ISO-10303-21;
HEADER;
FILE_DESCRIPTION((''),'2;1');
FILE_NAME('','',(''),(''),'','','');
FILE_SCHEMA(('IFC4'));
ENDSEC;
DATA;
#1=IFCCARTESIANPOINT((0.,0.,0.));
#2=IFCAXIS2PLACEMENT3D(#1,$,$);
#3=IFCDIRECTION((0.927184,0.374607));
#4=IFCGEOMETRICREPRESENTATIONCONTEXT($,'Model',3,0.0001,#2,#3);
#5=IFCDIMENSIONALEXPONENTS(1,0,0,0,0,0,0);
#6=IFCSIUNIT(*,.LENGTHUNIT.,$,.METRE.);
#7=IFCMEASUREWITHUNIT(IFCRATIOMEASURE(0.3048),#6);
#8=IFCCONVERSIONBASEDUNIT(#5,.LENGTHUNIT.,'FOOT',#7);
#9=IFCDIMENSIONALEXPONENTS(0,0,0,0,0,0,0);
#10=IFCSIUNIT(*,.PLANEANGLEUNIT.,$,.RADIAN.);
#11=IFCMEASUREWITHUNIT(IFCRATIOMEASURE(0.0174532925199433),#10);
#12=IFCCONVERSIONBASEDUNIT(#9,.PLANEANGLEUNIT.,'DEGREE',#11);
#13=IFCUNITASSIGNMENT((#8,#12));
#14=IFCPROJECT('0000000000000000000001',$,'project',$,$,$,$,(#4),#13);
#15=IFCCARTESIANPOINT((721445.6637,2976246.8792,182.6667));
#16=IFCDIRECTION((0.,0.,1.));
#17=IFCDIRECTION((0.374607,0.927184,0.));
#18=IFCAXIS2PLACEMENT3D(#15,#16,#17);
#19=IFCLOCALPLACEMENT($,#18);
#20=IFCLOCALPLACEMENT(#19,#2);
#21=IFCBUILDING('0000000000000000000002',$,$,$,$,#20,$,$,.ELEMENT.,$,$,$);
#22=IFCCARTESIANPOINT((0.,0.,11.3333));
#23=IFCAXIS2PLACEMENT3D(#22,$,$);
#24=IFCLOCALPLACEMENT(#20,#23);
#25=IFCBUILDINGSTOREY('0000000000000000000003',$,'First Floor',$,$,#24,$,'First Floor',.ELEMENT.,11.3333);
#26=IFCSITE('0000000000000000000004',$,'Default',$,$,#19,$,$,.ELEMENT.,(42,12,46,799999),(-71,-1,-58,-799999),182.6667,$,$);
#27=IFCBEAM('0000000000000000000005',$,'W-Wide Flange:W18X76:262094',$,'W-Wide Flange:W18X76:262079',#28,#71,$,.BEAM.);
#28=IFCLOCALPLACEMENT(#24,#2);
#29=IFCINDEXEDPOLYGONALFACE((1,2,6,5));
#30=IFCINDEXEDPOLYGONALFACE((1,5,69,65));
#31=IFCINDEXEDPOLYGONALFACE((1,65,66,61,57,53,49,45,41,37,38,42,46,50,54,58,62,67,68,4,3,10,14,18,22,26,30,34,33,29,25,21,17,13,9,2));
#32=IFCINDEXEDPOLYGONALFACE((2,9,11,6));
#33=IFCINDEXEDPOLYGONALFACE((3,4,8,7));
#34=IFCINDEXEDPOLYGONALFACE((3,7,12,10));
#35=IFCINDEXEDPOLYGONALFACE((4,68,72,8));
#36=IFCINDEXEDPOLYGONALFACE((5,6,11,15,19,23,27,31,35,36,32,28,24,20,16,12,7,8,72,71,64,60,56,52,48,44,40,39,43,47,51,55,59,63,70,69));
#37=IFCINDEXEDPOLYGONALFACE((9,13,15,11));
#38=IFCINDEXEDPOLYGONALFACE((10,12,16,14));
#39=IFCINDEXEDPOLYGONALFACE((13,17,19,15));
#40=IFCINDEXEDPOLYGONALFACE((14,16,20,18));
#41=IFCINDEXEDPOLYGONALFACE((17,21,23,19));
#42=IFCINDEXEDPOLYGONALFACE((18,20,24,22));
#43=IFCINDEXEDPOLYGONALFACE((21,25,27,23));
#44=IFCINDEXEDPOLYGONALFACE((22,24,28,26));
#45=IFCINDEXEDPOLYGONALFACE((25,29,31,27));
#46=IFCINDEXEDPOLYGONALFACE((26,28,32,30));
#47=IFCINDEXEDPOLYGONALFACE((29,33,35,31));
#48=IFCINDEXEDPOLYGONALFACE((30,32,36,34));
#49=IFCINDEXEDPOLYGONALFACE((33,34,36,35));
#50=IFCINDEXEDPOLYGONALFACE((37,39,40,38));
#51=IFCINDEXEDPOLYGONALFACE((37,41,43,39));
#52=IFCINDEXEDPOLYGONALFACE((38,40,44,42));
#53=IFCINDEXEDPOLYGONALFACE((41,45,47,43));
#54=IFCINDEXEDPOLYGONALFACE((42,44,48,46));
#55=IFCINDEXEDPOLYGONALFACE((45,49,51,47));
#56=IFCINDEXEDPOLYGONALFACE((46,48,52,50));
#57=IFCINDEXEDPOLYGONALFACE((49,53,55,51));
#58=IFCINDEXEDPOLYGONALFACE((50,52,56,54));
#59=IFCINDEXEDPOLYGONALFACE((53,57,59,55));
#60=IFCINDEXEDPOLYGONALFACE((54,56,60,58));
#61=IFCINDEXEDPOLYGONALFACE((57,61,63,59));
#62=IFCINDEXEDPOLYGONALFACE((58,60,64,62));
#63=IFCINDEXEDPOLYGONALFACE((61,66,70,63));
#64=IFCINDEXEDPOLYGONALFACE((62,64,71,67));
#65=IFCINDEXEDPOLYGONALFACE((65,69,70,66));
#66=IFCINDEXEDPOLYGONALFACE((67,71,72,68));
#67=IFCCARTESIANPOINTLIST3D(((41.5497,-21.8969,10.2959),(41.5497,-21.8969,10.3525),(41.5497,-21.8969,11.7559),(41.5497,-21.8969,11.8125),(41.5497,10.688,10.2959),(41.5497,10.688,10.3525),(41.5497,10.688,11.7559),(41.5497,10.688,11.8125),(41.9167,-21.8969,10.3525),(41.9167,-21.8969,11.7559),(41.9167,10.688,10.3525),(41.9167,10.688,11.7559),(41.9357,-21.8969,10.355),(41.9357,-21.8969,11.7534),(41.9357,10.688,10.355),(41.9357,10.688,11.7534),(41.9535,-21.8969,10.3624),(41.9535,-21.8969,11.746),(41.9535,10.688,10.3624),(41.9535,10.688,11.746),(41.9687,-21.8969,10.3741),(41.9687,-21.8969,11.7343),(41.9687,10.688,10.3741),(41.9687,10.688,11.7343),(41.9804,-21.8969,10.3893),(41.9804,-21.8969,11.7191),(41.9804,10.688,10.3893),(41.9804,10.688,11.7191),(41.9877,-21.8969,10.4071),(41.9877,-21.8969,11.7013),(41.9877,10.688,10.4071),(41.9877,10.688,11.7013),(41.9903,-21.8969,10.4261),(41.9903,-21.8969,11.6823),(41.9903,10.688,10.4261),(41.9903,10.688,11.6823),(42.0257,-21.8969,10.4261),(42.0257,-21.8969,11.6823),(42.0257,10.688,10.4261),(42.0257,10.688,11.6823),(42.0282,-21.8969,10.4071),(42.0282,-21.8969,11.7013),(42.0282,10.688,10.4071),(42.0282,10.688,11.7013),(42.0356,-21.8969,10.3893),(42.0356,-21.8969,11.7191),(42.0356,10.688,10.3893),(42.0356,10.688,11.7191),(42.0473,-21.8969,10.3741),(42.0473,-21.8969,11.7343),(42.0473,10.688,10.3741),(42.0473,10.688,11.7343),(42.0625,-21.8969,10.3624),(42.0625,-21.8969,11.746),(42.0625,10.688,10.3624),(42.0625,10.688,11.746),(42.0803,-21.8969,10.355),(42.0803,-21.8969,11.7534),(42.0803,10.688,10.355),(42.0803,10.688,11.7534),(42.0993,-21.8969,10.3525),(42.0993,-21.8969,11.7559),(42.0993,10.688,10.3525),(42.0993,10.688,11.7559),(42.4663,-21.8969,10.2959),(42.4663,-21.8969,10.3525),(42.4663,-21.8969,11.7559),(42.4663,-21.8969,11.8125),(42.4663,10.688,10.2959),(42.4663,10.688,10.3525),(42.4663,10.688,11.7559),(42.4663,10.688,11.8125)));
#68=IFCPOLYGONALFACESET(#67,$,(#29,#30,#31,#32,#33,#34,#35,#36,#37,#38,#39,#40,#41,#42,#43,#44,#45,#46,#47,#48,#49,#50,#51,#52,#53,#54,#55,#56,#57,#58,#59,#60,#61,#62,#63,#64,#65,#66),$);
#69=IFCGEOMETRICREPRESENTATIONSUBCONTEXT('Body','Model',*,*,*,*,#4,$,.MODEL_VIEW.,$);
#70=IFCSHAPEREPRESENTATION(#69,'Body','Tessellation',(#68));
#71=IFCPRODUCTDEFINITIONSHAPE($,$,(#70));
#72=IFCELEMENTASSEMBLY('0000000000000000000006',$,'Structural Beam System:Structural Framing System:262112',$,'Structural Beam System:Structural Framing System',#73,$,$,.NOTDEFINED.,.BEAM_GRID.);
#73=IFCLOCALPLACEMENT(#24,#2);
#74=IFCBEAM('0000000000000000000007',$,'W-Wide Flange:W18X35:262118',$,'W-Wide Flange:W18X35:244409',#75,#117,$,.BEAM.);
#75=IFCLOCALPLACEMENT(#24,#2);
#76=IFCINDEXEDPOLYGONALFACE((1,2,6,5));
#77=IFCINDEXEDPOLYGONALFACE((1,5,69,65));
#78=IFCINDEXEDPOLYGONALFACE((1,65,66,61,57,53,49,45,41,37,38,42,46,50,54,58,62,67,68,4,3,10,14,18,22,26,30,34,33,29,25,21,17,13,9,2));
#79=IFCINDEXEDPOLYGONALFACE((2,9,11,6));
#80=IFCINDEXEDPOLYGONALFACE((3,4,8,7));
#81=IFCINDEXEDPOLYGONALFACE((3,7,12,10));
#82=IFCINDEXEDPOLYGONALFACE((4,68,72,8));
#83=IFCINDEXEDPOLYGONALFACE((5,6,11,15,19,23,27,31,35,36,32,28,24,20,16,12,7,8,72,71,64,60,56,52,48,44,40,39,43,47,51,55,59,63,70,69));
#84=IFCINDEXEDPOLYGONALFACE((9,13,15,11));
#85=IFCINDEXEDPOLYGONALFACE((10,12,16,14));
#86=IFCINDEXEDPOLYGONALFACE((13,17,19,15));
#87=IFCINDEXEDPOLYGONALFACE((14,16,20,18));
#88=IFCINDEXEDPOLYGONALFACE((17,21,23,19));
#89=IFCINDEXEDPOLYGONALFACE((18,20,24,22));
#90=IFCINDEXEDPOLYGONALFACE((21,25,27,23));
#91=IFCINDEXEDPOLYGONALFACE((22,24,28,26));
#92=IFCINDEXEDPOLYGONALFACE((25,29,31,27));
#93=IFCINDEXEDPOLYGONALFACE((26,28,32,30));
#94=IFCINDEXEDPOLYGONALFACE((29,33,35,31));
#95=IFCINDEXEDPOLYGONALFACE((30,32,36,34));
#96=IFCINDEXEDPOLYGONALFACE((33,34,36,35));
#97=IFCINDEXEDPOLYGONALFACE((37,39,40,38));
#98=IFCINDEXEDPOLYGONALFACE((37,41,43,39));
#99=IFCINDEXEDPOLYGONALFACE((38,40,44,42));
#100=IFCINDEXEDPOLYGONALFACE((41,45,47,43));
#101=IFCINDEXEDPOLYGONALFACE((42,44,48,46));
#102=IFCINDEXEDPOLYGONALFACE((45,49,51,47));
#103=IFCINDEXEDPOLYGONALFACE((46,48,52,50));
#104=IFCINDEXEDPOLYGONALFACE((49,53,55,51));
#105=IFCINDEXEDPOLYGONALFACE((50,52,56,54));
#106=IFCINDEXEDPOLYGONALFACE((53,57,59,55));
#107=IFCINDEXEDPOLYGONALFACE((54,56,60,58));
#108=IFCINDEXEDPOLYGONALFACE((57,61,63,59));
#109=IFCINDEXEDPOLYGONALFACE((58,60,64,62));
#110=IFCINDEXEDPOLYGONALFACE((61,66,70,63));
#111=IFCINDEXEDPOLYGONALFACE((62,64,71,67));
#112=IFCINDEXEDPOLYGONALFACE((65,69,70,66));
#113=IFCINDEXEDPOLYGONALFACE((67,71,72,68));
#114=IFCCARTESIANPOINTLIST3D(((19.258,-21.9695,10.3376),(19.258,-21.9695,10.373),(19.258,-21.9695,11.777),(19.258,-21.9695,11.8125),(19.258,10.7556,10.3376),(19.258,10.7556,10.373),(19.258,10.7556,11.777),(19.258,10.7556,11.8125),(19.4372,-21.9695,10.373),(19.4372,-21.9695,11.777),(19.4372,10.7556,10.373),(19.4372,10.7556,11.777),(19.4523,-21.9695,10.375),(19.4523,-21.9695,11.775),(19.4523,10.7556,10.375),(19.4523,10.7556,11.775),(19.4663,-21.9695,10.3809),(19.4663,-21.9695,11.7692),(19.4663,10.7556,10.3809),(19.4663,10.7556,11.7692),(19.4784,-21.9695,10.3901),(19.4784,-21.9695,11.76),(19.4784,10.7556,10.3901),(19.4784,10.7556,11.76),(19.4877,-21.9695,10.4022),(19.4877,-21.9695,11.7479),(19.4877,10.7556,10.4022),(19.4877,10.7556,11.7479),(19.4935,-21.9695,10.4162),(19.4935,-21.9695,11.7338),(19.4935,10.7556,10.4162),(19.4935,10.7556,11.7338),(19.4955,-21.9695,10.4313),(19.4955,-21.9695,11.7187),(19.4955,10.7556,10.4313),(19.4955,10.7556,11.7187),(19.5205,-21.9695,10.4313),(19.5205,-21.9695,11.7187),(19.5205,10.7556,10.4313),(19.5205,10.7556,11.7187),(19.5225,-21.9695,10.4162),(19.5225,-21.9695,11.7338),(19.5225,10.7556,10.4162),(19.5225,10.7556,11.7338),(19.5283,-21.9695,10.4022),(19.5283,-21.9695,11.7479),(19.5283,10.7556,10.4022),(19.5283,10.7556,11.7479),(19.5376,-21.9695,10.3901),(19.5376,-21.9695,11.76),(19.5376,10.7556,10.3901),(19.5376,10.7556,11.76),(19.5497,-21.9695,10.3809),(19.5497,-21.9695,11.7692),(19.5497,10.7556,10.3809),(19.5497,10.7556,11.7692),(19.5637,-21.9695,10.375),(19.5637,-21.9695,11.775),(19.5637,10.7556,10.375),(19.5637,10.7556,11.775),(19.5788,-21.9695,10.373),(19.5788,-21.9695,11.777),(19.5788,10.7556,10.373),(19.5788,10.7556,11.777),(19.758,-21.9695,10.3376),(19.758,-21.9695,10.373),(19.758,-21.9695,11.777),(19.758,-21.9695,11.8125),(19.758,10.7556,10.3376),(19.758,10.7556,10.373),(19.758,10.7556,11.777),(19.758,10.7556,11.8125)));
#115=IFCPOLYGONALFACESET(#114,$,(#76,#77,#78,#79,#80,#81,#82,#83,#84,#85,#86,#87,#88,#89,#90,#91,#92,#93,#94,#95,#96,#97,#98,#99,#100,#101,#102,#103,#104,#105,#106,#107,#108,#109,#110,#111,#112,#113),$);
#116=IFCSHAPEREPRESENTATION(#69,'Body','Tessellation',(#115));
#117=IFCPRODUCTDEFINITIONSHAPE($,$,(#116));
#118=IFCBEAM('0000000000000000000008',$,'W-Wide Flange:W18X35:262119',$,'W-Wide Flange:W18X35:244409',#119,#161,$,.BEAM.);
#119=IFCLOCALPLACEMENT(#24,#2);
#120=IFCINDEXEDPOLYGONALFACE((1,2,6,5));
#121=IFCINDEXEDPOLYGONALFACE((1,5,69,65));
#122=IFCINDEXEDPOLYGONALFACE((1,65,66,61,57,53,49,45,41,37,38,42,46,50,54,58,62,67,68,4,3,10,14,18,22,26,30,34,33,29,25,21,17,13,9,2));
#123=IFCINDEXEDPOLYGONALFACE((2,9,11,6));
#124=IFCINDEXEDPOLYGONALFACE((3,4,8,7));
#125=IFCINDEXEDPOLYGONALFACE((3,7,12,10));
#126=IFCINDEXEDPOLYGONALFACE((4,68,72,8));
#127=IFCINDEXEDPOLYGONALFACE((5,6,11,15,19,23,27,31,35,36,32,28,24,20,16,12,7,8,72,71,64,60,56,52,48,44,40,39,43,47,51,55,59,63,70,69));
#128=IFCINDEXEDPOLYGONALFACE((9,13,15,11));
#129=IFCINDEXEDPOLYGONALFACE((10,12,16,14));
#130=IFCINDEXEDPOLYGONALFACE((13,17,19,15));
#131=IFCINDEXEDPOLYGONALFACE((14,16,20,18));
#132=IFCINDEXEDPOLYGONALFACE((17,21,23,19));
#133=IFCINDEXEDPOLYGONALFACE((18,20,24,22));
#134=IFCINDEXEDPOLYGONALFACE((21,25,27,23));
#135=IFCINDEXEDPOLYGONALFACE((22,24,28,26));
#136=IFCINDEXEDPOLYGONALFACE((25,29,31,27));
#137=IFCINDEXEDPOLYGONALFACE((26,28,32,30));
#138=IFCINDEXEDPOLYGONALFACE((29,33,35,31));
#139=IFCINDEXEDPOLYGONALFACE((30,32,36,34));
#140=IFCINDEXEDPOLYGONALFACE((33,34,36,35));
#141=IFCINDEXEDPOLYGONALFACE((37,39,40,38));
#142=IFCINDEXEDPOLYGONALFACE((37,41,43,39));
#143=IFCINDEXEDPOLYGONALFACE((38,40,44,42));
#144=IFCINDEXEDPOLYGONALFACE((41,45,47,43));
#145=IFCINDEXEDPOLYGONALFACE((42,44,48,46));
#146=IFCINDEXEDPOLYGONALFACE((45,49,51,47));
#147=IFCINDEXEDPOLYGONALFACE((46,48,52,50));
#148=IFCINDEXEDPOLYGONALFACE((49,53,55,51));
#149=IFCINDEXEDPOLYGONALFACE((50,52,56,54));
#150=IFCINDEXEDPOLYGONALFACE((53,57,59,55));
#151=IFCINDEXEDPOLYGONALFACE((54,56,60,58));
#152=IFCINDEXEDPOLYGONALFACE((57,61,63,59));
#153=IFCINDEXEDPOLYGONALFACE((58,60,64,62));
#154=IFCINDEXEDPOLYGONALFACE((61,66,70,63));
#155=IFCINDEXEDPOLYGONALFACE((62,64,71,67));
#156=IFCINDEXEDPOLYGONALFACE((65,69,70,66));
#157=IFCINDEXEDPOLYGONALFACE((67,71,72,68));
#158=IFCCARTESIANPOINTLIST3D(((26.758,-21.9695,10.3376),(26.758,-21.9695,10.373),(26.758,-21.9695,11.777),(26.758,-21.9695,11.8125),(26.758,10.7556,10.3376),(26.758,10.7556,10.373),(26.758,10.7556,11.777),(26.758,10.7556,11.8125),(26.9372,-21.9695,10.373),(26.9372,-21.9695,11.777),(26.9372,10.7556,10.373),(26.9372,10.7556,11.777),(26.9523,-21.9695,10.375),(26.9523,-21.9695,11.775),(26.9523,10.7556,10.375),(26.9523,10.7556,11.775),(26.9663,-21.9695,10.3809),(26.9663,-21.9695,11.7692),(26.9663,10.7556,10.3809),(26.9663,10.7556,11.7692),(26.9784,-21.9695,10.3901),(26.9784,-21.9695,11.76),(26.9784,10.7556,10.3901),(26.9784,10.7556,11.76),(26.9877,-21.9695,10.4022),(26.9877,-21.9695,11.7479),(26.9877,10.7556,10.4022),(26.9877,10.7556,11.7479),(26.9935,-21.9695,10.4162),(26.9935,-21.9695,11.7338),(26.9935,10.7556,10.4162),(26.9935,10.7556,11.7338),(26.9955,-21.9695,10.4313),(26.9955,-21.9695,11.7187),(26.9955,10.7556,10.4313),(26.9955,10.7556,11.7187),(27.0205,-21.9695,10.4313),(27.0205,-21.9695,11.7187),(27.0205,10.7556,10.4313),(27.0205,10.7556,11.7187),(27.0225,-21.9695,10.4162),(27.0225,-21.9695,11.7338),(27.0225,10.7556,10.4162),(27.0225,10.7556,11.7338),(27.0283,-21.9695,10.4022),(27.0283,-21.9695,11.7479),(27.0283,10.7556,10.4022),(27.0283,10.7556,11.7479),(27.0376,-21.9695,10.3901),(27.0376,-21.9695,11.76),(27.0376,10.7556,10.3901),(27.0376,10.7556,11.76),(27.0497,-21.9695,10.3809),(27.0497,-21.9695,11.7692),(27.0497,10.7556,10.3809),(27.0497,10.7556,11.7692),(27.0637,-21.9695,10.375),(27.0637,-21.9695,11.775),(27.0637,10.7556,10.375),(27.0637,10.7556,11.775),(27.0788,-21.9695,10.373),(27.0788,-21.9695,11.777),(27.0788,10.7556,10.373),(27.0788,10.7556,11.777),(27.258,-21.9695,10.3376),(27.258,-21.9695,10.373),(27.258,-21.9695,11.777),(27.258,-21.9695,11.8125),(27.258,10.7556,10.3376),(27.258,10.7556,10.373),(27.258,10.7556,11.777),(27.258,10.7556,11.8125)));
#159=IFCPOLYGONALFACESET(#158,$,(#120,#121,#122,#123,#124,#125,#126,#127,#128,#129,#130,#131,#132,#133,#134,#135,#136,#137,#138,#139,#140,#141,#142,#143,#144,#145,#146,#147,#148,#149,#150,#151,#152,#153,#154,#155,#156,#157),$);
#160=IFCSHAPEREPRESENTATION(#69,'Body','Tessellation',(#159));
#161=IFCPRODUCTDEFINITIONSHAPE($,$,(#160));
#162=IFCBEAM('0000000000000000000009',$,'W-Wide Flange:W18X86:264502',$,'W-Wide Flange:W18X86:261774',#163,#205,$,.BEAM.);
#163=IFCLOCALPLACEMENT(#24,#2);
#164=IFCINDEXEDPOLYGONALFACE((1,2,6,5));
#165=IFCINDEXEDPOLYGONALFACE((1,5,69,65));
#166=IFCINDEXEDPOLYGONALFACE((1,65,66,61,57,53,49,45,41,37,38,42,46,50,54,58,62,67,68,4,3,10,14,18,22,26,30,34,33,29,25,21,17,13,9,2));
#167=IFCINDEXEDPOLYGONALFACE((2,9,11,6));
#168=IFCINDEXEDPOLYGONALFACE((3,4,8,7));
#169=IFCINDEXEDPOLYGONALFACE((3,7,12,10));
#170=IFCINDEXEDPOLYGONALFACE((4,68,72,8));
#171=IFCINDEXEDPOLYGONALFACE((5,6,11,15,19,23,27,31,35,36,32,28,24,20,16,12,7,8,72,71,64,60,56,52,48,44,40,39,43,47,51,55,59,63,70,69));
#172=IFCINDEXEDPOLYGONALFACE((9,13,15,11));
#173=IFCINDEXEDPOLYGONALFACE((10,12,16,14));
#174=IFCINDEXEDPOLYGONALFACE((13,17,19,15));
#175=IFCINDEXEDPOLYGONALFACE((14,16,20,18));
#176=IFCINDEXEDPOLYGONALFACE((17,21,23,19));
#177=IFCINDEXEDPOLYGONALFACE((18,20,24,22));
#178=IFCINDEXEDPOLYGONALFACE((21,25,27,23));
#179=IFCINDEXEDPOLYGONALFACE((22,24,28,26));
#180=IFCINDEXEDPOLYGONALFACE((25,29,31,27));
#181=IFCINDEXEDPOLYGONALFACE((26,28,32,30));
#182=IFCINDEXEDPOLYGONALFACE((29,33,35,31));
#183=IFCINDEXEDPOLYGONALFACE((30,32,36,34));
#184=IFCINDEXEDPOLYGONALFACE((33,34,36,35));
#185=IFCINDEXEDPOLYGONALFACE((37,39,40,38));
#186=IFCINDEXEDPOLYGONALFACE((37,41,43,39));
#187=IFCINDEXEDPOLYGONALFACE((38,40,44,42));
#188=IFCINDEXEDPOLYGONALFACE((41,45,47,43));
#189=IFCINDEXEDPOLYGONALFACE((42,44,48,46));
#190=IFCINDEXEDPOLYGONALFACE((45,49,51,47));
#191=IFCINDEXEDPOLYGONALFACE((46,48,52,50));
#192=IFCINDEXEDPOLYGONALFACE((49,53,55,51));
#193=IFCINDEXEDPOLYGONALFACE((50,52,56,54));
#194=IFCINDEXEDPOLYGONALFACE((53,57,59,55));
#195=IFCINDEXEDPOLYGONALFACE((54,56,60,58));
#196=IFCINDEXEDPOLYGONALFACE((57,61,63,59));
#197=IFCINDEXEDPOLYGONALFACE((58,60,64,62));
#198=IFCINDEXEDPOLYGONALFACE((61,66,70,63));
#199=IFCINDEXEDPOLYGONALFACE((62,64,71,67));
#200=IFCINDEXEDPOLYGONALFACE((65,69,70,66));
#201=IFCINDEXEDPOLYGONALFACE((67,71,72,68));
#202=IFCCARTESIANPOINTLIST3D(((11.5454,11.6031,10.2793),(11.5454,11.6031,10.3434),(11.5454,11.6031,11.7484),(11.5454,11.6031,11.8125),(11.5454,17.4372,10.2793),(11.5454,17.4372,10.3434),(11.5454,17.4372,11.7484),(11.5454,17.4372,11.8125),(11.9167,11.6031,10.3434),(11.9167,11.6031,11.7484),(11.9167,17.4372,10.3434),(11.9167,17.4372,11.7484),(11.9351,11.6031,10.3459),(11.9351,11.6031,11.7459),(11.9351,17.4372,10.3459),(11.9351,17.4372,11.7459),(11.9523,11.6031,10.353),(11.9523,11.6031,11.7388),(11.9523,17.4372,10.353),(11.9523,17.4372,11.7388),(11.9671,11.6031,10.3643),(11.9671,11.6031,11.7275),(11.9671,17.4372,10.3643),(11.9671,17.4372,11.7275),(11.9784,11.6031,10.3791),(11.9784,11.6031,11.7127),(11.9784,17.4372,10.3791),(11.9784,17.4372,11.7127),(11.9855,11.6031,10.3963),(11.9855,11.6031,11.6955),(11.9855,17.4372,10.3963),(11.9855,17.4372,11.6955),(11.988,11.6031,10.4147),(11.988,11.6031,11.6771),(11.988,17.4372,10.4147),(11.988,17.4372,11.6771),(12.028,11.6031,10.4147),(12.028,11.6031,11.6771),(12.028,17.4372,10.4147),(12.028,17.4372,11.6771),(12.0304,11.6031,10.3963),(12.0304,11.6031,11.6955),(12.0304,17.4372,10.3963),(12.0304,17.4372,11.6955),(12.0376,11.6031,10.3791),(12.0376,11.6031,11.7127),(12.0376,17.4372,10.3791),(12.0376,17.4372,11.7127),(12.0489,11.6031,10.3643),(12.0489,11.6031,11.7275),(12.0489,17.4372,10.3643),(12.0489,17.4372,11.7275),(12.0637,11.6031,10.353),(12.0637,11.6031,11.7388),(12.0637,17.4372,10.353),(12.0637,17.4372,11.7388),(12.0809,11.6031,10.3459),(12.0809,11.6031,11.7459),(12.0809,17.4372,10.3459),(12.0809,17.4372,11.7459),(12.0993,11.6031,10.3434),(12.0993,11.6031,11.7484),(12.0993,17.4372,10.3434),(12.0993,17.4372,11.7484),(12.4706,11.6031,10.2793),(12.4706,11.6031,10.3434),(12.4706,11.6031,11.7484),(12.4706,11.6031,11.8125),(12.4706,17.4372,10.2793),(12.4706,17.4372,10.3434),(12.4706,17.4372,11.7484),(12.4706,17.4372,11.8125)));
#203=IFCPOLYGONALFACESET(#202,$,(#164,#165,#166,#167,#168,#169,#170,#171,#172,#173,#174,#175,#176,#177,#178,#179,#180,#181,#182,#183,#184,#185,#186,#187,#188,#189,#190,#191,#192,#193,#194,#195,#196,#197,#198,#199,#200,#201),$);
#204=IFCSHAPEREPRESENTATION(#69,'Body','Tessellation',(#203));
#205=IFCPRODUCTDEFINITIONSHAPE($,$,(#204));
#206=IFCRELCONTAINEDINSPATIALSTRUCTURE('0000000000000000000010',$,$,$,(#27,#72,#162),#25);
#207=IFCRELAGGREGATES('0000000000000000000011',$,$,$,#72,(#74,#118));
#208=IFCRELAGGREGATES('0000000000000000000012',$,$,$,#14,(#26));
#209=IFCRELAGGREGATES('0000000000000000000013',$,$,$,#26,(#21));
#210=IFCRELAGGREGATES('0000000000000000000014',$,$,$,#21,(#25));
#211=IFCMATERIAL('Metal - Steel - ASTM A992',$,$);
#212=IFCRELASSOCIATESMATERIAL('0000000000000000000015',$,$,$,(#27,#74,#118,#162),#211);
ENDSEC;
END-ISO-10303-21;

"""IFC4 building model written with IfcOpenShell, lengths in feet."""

from ifc_helpers import new_model, entity, si_unit, converted_unit, direction, frame, frame_2d, origin, place, context, subcontext, project, spatial, i_section, extrude, material, element, aggregate, save


model = new_model("IFC4")

# Units and contexts
model_context = context("Model", 3, precision=0.0001, world=origin(), true_north=direction((0.927184, 0.374607)))
body_context = subcontext(model_context, "Body", "Model", "MODEL_VIEW")
ifc_project = project(units=[converted_unit("LENGTHUNIT", "FOOT", entity("IfcRatioMeasure", 0.3048), si_unit("LENGTHUNIT", "METRE"), dimensions=[1, 0, 0, 0, 0, 0, 0]), converted_unit("PLANEANGLEUNIT", "DEGREE", entity("IfcRatioMeasure", 0.0174532925199433), si_unit("PLANEANGLEUNIT", "RADIAN"), dimensions=[0, 0, 0, 0, 0, 0, 0])], contexts=[model_context])

# Site, building, storey
site_placement = place(None, frame((721445.6637, 2976246.8792, 182.6667), z_axis=(0.0, 0.0, 1.0), x_axis=(0.374607, 0.927184, 0.0)))
site = spatial("IfcSite", under=ifc_project, at=site_placement, Name="Default", CompositionType="ELEMENT", RefLatitude=(42, 12, 46, 799999), RefLongitude=(-71, -1, -58, -799999), RefElevation=182.6667)
building_placement = place(site_placement, origin())
building = spatial("IfcBuilding", under=site, at=building_placement, CompositionType="ELEMENT")
storey_placement = place(building_placement, frame((0.0, 0.0, 11.3333)))
storey = spatial("IfcBuildingStorey", under=building, at=storey_placement, Name="First Floor", LongName="First Floor", CompositionType="ELEMENT", Elevation=11.3333)

# Shared definitions
ifc_material_1 = material(Name="Metal - Steel - ASTM A992")

# Beam
beam_1_placement = place(storey_placement, frame((42.008, -22.3544, 11.8125), z_axis=(0.0, 0.0, 1.0), x_axis=(0.0, 1.0, 0.0)))
element("IfcBeam", 1, at=beam_1_placement, inside=storey, material=ifc_material_1, Name="W-Wide Flange:W18X76:262094", ObjectType="W-Wide Flange:W18X76:262079", PredefinedType="BEAM", context=body_context, shape_type="SweptSolid", body=[
    extrude(i_section(OverallWidth=0.9167, OverallDepth=1.5166, WebThickness=0.0355, FlangeThickness=0.0566, FilletRadius=0.0736, at=frame_2d((0.0, 0.0), x_axis=(0.0, 1.0))), frame((0.4575, 0.0, -0.7583), z_axis=(1.0, 0.0, 0.0), x_axis=(0.0, 0.0, -1.0)), (0.0, 0.0, 1.0), 32.585),
])

# Element assembly, beams
assembly_1_placement = place(storey_placement, origin())
assembly_1 = element("IfcElementAssembly", 2, at=assembly_1_placement, inside=storey, Name="Structural Beam System:Structural Framing System:262112", ObjectType="Structural Beam System:Structural Framing System", AssemblyPlace="NOTDEFINED", PredefinedType="BEAM_GRID")
beam_2_placement = place(assembly_1_placement, frame((19.508, -22.3544, 11.8125), z_axis=(0.0, 0.0, 1.0), x_axis=(0.0, 1.0, 0.0)))
beam_2 = element("IfcBeam", 3, at=beam_2_placement, material=ifc_material_1, Name="W-Wide Flange:W18X35:262118", ObjectType="W-Wide Flange:W18X35:244409", PredefinedType="BEAM", context=body_context, shape_type="SweptSolid", body=[
    extrude(i_section(OverallWidth=0.5, OverallDepth=1.4749, WebThickness=0.0251, FlangeThickness=0.0355, FilletRadius=0.0583, at=frame_2d((0.0, 0.0), x_axis=(0.0, 1.0))), frame((0.3849, 0.0, -0.7375), z_axis=(1.0, 0.0, 0.0), x_axis=(0.0, 0.0, -1.0)), (0.0, 0.0, 1.0), 32.7251),
])
beam_3_placement = place(assembly_1_placement, frame((27.008, -22.3544, 11.8125), z_axis=(0.0, 0.0, 1.0), x_axis=(0.0, 1.0, 0.0)))
beam_3 = element("IfcBeam", 4, at=beam_3_placement, material=ifc_material_1, Name="W-Wide Flange:W18X35:262119", ObjectType="W-Wide Flange:W18X35:244409", PredefinedType="BEAM", context=body_context, shape_type="SweptSolid", body=[
    extrude(i_section(OverallWidth=0.5, OverallDepth=1.4749, WebThickness=0.0251, FlangeThickness=0.0355, FilletRadius=0.0583, at=frame_2d((0.0, 0.0), x_axis=(0.0, 1.0))), frame((0.3849, 0.0, -0.7375), z_axis=(1.0, 0.0, 0.0), x_axis=(0.0, 0.0, -1.0)), (0.0, 0.0, 1.0), 32.7251),
])
aggregate(assembly_1, [beam_2, beam_3])

# Beam
beam_4_placement = place(storey_placement, frame((12.008, 11.1456, 11.8125), z_axis=(0.0, 0.0, 1.0), x_axis=(0.0, 1.0, 0.0)))
element("IfcBeam", 5, at=beam_4_placement, inside=storey, material=ifc_material_1, Name="W-Wide Flange:W18X86:264502", ObjectType="W-Wide Flange:W18X86:261774", PredefinedType="BEAM", context=body_context, shape_type="SweptSolid", body=[
    extrude(i_section(OverallWidth=0.9251, OverallDepth=1.5332, WebThickness=0.04, FlangeThickness=0.0641, FilletRadius=0.0713, at=frame_2d((0.0, 0.0), x_axis=(0.0, 1.0))), frame((0.4575, 0.0, -0.7666), z_axis=(1.0, 0.0, 0.0), x_axis=(0.0, 0.0, -1.0)), (0.0, 0.0, 1.0), 5.8341),
])

save(model, "model.ifc")
